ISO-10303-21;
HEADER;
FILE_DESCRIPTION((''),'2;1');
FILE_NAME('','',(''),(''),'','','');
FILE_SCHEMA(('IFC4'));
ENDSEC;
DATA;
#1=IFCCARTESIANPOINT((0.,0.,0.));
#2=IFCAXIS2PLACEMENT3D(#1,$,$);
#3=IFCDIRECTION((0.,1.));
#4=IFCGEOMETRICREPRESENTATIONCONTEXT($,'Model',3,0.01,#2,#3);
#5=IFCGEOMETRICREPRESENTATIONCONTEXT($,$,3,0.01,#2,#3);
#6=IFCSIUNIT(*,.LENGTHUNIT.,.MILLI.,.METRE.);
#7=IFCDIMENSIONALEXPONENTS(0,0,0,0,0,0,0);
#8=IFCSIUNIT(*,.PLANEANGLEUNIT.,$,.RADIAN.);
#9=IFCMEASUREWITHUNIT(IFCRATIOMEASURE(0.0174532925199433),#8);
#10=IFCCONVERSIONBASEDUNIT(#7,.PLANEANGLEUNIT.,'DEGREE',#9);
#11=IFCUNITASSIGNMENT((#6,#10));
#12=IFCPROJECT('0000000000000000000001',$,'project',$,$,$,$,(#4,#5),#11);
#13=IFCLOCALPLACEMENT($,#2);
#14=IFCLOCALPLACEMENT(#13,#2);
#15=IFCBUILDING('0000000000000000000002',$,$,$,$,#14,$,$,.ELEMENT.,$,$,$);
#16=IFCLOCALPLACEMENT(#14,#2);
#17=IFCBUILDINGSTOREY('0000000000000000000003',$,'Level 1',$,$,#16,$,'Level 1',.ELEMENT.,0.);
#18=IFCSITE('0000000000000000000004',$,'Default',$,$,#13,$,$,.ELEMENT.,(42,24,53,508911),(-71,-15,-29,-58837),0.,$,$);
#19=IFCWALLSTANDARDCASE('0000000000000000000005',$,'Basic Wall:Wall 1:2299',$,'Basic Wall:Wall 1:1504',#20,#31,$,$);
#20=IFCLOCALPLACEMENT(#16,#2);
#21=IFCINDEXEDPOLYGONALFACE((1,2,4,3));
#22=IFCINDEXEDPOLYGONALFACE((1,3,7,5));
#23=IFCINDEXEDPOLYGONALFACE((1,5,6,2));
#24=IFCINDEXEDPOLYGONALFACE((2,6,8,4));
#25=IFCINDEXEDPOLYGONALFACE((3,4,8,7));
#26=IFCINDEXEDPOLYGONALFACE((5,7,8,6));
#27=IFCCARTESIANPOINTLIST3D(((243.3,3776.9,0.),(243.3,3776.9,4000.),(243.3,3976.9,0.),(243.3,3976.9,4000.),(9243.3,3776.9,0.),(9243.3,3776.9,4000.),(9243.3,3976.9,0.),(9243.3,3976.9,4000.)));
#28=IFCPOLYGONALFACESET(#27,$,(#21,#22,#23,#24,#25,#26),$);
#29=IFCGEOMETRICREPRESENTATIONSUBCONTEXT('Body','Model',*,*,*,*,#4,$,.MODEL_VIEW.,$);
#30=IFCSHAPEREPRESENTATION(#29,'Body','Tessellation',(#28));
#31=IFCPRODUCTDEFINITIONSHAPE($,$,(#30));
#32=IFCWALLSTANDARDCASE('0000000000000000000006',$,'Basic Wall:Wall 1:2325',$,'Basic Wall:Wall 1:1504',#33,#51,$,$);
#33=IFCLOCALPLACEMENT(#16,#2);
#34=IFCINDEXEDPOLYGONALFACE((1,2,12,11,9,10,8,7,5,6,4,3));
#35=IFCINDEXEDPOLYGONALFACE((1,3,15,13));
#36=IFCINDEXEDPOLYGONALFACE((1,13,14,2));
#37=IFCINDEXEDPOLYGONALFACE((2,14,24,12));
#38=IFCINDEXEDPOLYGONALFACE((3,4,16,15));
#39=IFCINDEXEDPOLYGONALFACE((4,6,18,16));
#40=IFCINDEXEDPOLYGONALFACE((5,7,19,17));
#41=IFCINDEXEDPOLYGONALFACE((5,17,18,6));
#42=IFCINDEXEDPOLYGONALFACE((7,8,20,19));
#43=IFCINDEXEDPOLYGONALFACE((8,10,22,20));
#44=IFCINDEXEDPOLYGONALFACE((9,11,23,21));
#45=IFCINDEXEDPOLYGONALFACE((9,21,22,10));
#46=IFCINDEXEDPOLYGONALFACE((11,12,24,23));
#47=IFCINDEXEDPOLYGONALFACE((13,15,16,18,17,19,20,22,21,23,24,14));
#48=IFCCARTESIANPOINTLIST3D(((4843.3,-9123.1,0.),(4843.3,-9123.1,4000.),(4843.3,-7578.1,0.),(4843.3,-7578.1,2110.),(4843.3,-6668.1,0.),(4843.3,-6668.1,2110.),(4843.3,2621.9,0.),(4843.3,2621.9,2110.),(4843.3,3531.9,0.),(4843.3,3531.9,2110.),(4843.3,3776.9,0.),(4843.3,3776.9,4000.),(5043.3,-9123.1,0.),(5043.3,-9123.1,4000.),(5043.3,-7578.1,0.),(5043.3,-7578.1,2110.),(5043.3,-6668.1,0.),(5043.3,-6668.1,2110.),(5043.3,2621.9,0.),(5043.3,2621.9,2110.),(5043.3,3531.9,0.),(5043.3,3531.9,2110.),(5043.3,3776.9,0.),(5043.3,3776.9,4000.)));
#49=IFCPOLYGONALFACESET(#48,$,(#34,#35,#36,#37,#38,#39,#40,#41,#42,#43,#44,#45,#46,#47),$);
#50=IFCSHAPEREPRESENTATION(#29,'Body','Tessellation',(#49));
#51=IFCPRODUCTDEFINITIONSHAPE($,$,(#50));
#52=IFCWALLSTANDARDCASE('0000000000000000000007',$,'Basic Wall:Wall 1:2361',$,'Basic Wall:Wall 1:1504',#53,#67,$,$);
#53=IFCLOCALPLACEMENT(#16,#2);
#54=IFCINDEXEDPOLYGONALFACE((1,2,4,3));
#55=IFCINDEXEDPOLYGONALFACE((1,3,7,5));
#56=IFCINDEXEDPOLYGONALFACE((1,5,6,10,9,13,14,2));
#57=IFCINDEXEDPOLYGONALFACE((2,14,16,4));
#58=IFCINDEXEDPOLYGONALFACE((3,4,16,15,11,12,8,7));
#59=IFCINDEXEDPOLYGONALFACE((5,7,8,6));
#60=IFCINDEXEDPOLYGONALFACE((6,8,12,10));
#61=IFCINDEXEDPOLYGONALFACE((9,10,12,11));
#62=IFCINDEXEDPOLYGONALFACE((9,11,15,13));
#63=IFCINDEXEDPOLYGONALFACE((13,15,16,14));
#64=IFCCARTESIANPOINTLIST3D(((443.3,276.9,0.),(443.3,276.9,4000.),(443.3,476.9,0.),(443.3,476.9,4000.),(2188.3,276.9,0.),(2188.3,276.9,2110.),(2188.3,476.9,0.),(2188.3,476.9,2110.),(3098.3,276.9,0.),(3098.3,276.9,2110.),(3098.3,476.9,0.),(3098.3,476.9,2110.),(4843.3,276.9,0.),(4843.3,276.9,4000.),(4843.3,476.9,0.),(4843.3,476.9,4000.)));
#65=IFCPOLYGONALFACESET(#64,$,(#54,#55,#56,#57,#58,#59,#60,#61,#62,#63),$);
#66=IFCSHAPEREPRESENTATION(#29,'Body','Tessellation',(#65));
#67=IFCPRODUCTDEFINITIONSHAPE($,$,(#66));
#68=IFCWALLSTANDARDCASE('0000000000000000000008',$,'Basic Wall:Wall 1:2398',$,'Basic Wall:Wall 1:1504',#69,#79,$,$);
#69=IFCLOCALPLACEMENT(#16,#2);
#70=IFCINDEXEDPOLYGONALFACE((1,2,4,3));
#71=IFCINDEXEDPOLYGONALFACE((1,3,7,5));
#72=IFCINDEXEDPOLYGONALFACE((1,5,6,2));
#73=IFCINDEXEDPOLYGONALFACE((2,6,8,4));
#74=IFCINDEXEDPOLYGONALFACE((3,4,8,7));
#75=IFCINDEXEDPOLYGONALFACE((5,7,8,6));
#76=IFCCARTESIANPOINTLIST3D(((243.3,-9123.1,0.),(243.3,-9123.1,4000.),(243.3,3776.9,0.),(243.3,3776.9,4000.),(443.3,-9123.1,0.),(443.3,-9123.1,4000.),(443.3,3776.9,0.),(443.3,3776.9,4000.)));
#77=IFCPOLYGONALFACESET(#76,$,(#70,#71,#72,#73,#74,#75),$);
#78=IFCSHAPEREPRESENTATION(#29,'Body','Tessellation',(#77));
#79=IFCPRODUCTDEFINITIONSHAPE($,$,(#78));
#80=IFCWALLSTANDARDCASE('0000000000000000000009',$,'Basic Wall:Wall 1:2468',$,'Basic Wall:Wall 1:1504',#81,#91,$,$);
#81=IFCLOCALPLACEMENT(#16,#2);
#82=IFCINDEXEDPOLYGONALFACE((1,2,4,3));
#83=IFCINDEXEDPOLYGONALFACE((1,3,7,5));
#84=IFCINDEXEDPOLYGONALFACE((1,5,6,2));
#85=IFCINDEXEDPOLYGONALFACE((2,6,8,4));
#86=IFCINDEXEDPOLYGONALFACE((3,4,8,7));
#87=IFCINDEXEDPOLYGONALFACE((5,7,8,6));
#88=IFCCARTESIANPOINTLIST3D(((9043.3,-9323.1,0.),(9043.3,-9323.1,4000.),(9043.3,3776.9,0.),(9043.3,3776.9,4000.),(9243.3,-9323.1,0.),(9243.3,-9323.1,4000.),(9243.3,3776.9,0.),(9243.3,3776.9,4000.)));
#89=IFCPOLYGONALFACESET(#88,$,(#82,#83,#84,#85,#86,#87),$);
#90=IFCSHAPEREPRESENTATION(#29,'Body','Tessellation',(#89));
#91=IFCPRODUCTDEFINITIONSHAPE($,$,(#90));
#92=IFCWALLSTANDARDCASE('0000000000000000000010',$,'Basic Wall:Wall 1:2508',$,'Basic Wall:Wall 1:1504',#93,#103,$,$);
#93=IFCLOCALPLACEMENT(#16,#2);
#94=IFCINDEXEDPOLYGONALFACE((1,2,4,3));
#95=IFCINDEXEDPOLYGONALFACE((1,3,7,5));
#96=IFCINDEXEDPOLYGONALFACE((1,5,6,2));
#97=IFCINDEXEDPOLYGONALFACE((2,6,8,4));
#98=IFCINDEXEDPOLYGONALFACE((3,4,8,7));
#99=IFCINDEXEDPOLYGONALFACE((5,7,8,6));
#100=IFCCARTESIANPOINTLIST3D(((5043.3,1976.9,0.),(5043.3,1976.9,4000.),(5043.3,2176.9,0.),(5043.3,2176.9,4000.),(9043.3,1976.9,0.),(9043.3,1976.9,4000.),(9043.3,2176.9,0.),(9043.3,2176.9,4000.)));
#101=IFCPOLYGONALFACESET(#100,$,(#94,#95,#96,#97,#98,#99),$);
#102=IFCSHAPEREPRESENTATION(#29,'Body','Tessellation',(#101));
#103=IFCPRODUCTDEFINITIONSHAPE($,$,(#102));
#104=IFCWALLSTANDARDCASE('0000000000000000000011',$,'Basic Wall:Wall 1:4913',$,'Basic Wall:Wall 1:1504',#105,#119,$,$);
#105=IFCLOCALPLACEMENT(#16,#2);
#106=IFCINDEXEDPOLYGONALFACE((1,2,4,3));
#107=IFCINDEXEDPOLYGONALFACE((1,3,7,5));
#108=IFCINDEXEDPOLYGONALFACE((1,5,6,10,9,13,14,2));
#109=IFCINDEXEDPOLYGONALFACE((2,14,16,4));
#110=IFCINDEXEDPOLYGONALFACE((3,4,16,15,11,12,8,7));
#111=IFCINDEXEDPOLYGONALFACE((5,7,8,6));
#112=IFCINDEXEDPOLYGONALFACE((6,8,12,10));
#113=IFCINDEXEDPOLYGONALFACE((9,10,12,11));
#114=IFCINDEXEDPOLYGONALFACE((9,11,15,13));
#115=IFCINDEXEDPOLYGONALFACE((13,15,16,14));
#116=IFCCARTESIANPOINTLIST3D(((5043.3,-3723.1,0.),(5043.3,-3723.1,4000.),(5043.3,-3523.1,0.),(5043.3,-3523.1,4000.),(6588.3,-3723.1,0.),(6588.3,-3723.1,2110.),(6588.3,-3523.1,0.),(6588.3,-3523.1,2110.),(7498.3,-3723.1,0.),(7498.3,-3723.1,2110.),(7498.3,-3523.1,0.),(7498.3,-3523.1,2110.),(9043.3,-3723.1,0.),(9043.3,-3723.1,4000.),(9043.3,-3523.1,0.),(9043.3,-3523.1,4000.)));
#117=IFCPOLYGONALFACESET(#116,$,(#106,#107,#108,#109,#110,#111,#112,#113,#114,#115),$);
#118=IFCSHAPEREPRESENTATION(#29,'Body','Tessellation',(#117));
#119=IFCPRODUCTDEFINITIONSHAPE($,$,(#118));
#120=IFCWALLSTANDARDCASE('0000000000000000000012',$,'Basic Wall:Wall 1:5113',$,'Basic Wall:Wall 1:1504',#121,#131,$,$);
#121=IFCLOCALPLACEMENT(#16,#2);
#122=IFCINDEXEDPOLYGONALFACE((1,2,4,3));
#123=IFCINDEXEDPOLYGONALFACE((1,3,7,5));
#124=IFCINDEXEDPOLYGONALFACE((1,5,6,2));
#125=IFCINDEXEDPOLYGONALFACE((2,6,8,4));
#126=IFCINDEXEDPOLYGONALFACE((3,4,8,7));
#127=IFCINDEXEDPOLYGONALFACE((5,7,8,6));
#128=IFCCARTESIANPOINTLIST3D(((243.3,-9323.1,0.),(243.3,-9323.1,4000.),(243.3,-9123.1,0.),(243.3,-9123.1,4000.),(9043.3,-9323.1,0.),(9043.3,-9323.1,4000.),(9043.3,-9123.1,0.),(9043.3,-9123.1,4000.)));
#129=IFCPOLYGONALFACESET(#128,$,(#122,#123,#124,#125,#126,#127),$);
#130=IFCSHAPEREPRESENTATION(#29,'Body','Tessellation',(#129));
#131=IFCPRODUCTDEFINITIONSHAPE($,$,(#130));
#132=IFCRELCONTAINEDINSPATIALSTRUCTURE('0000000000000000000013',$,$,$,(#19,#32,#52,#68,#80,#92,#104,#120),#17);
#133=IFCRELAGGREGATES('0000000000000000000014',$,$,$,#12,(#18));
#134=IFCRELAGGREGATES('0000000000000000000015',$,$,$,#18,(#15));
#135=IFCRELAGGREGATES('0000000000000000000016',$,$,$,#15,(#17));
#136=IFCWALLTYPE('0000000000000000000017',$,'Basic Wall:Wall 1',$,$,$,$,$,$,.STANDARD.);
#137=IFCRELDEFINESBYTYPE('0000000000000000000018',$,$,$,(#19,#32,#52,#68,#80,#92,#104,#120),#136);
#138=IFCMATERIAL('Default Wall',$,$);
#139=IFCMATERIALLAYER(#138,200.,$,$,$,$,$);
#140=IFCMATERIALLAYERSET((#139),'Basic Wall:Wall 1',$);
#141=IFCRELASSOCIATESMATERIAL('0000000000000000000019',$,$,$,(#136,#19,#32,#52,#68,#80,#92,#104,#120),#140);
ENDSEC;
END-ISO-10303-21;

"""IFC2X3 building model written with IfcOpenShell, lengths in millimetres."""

from ifc_helpers import new_model, entity, si_unit, converted_unit, direction, frame, frame_2d, origin, place, context, subcontext, project, spatial, rectangle, extrude, material, layer, layer_set, layer_usage, type_object, element, save


model = new_model("IFC2X3")

# Units and contexts
model_context = context("Model", 3, precision=0.01, world=origin(), true_north=direction((0.0, 1.0)))
context_of_model = context(None, 3, precision=0.01, world=origin(), true_north=direction((0.0, 1.0)))
body_context = subcontext(model_context, "Body", "Model", "MODEL_VIEW")
ifc_project = project(units=[si_unit("LENGTHUNIT", "METRE", prefix="MILLI"), converted_unit("PLANEANGLEUNIT", "DEGREE", entity("IfcRatioMeasure", 0.0174532925199433), si_unit("PLANEANGLEUNIT", "RADIAN"), dimensions=[0, 0, 0, 0, 0, 0, 0])], contexts=[model_context, context_of_model])

# Site, building, storey
site_placement = place(None, origin())
site = spatial("IfcSite", under=ifc_project, at=site_placement, Name="Default", CompositionType="ELEMENT", RefLatitude=(42, 24, 53, 508911), RefLongitude=(-71, -15, -29, -58837), RefElevation=0.0)
building_placement = place(site_placement, origin())
building = spatial("IfcBuilding", under=site, at=building_placement, CompositionType="ELEMENT")
storey_placement = place(building_placement, origin())
storey = spatial("IfcBuildingStorey", under=building, at=storey_placement, Name="Level 1", LongName="Level 1", CompositionType="ELEMENT", Elevation=0.0)

# Wall
ifc_material_1 = material(Name="Default Wall")
ifc_layer = layer(ifc_material_1, 200.0)
ifc_layer_set = layer_set([ifc_layer], Name="Basic Wall:Wall 1")
ifc_layer_usage_1 = layer_usage(ifc_layer_set, "AXIS2", "NEGATIVE", 100.0)
wall_type = type_object("IfcWallType", Name="Basic Wall:Wall 1", PredefinedType="STANDARD", material=ifc_layer_set)
wall_1_placement = place(storey_placement, frame((243.3, 3876.9, 0.0)))
element("IfcWallStandardCase", 1, at=wall_1_placement, inside=storey, type_object=wall_type, material=ifc_layer_usage_1, Name="Basic Wall:Wall 1:2299", ObjectType="Basic Wall:Wall 1:1504", context=body_context, shape_type="SweptSolid", body=[
    extrude(rectangle(XDim=9000.0, YDim=200.0, at=frame_2d((4500.0, 0.0), x_axis=(-1.0, 0.0))), origin(), (0.0, 0.0, 1.0), 4000.0),
])

# Wall, openings
ifc_layer_usage_2 = layer_usage(ifc_layer_set, "AXIS2", "NEGATIVE", 100.0)
wall_2_placement = place(storey_placement, frame((4943.3, 3776.9, 0.0), z_axis=(0.0, 0.0, 1.0), x_axis=(0.0, -1.0, 0.0)))
wall_2 = element("IfcWallStandardCase", 2, at=wall_2_placement, inside=storey, type_object=wall_type, material=ifc_layer_usage_2, Name="Basic Wall:Wall 1:2325", ObjectType="Basic Wall:Wall 1:1504", context=body_context, shape_type="SweptSolid", body=[
    extrude(rectangle(XDim=12900.0, YDim=200.0, at=frame_2d((6450.0, 0.0), x_axis=(-1.0, 0.0))), origin(), (0.0, 0.0, 1.0), 4000.0),
])
opening_1_placement = place(wall_2_placement, frame((245.0, -100.0, 0.0)))
element("IfcOpeningElement", 3, at=opening_1_placement, cuts=wall_2, ObjectType="Opening", context=body_context, shape_type="SweptSolid", body=[
    extrude(rectangle(XDim=2110.0, YDim=910.0, at=frame_2d((1055.0, 455.0), x_axis=(-1.0, 0.0))), frame((0.0, 0.0, 0.0), z_axis=(0.0, 1.0, 0.0), x_axis=(0.0, 0.0, 1.0)), (0.0, 0.0, 1.0), 200.0),
])
opening_2_placement = place(wall_2_placement, frame((11355.0, 100.0, 0.0)))
element("IfcOpeningElement", 4, at=opening_2_placement, cuts=wall_2, ObjectType="Opening", context=body_context, shape_type="SweptSolid", body=[
    extrude(rectangle(XDim=2110.0, YDim=910.0, at=frame_2d((1055.0, 455.0), x_axis=(-1.0, 0.0))), frame((0.0, 0.0, 0.0), z_axis=(0.0, -1.0, 0.0), x_axis=(0.0, 0.0, 1.0)), (0.0, 0.0, 1.0), 200.0),
])

# Wall, opening
ifc_layer_usage_3 = layer_usage(ifc_layer_set, "AXIS2", "NEGATIVE", 100.0)
wall_3_placement = place(storey_placement, frame((4843.3, 376.9, 0.0), z_axis=(0.0, 0.0, 1.0), x_axis=(-1.0, 0.0, 0.0)))
wall_3 = element("IfcWallStandardCase", 5, at=wall_3_placement, inside=storey, type_object=wall_type, material=ifc_layer_usage_3, Name="Basic Wall:Wall 1:2361", ObjectType="Basic Wall:Wall 1:1504", context=body_context, shape_type="SweptSolid", body=[
    extrude(rectangle(XDim=4400.0, YDim=200.0, at=frame_2d((2200.0, 0.0), x_axis=(-1.0, 0.0))), origin(), (0.0, 0.0, 1.0), 4000.0),
])
opening_3_placement = place(wall_3_placement, frame((2655.0, 100.0, 0.0)))
element("IfcOpeningElement", 6, at=opening_3_placement, cuts=wall_3, ObjectType="Opening", context=body_context, shape_type="SweptSolid", body=[
    extrude(rectangle(XDim=2110.0, YDim=910.0, at=frame_2d((1055.0, 455.0), x_axis=(-1.0, 0.0))), frame((0.0, 0.0, 0.0), z_axis=(0.0, -1.0, 0.0), x_axis=(0.0, 0.0, 1.0)), (0.0, 0.0, 1.0), 200.0),
])

# Walls
ifc_layer_usage_4 = layer_usage(ifc_layer_set, "AXIS2", "NEGATIVE", 100.0)
wall_4_placement = place(storey_placement, frame((343.3, -9123.1, 0.0), z_axis=(0.0, 0.0, 1.0), x_axis=(0.0, 1.0, 0.0)))
element("IfcWallStandardCase", 7, at=wall_4_placement, inside=storey, type_object=wall_type, material=ifc_layer_usage_4, Name="Basic Wall:Wall 1:2398", ObjectType="Basic Wall:Wall 1:1504", context=body_context, shape_type="SweptSolid", body=[
    extrude(rectangle(XDim=12900.0, YDim=200.0, at=frame_2d((6450.0, 0.0), x_axis=(-1.0, 0.0))), origin(), (0.0, 0.0, 1.0), 4000.0),
])
ifc_layer_usage_5 = layer_usage(ifc_layer_set, "AXIS2", "NEGATIVE", 100.0)
wall_5_placement = place(storey_placement, frame((9143.3, 3776.9, 0.0), z_axis=(0.0, 0.0, 1.0), x_axis=(0.0, -1.0, 0.0)))
element("IfcWallStandardCase", 8, at=wall_5_placement, inside=storey, type_object=wall_type, material=ifc_layer_usage_5, Name="Basic Wall:Wall 1:2468", ObjectType="Basic Wall:Wall 1:1504", context=body_context, shape_type="SweptSolid", body=[
    extrude(rectangle(XDim=13100.0, YDim=200.0, at=frame_2d((6550.0, 0.0), x_axis=(-1.0, 0.0))), origin(), (0.0, 0.0, 1.0), 4000.0),
])
ifc_layer_usage_6 = layer_usage(ifc_layer_set, "AXIS2", "NEGATIVE", 100.0)
wall_6_placement = place(storey_placement, frame((9043.3, 2076.9, 0.0), z_axis=(0.0, 0.0, 1.0), x_axis=(-1.0, 0.0, 0.0)))
element("IfcWallStandardCase", 9, at=wall_6_placement, inside=storey, type_object=wall_type, material=ifc_layer_usage_6, Name="Basic Wall:Wall 1:2508", ObjectType="Basic Wall:Wall 1:1504", context=body_context, shape_type="SweptSolid", body=[
    extrude(rectangle(XDim=4000.0, YDim=200.0, at=frame_2d((2000.0, 0.0), x_axis=(-1.0, 0.0))), origin(), (0.0, 0.0, 1.0), 4000.0),
])

# Wall, opening
ifc_layer_usage_7 = layer_usage(ifc_layer_set, "AXIS2", "NEGATIVE", 100.0)
wall_7_placement = place(storey_placement, frame((9043.3, -3623.1, 0.0), z_axis=(0.0, 0.0, 1.0), x_axis=(-1.0, 0.0, 0.0)))
wall_7 = element("IfcWallStandardCase", 10, at=wall_7_placement, inside=storey, type_object=wall_type, material=ifc_layer_usage_7, Name="Basic Wall:Wall 1:4913", ObjectType="Basic Wall:Wall 1:1504", context=body_context, shape_type="SweptSolid", body=[
    extrude(rectangle(XDim=4000.0, YDim=200.0, at=frame_2d((2000.0, 0.0), x_axis=(-1.0, 0.0))), origin(), (0.0, 0.0, 1.0), 4000.0),
])
opening_4_placement = place(wall_7_placement, frame((1545.0, -100.0, 0.0)))
element("IfcOpeningElement", 11, at=opening_4_placement, cuts=wall_7, ObjectType="Opening", context=body_context, shape_type="SweptSolid", body=[
    extrude(rectangle(XDim=2110.0, YDim=910.0, at=frame_2d((1055.0, 455.0), x_axis=(-1.0, 0.0))), frame((0.0, 0.0, 0.0), z_axis=(0.0, 1.0, 0.0), x_axis=(0.0, 0.0, 1.0)), (0.0, 0.0, 1.0), 200.0),
])

# Wall
ifc_layer_usage_8 = layer_usage(ifc_layer_set, "AXIS2", "NEGATIVE", 100.0)
wall_8_placement = place(storey_placement, frame((9043.3, -9223.1, 0.0), z_axis=(0.0, 0.0, 1.0), x_axis=(-1.0, 0.0, 0.0)))
element("IfcWallStandardCase", 12, at=wall_8_placement, inside=storey, type_object=wall_type, material=ifc_layer_usage_8, Name="Basic Wall:Wall 1:5113", ObjectType="Basic Wall:Wall 1:1504", context=body_context, shape_type="SweptSolid", body=[
    extrude(rectangle(XDim=8800.0, YDim=200.0, at=frame_2d((4400.0, 0.0), x_axis=(-1.0, 0.0))), origin(), (0.0, 0.0, 1.0), 4000.0),
])

save(model, "model.ifc")
